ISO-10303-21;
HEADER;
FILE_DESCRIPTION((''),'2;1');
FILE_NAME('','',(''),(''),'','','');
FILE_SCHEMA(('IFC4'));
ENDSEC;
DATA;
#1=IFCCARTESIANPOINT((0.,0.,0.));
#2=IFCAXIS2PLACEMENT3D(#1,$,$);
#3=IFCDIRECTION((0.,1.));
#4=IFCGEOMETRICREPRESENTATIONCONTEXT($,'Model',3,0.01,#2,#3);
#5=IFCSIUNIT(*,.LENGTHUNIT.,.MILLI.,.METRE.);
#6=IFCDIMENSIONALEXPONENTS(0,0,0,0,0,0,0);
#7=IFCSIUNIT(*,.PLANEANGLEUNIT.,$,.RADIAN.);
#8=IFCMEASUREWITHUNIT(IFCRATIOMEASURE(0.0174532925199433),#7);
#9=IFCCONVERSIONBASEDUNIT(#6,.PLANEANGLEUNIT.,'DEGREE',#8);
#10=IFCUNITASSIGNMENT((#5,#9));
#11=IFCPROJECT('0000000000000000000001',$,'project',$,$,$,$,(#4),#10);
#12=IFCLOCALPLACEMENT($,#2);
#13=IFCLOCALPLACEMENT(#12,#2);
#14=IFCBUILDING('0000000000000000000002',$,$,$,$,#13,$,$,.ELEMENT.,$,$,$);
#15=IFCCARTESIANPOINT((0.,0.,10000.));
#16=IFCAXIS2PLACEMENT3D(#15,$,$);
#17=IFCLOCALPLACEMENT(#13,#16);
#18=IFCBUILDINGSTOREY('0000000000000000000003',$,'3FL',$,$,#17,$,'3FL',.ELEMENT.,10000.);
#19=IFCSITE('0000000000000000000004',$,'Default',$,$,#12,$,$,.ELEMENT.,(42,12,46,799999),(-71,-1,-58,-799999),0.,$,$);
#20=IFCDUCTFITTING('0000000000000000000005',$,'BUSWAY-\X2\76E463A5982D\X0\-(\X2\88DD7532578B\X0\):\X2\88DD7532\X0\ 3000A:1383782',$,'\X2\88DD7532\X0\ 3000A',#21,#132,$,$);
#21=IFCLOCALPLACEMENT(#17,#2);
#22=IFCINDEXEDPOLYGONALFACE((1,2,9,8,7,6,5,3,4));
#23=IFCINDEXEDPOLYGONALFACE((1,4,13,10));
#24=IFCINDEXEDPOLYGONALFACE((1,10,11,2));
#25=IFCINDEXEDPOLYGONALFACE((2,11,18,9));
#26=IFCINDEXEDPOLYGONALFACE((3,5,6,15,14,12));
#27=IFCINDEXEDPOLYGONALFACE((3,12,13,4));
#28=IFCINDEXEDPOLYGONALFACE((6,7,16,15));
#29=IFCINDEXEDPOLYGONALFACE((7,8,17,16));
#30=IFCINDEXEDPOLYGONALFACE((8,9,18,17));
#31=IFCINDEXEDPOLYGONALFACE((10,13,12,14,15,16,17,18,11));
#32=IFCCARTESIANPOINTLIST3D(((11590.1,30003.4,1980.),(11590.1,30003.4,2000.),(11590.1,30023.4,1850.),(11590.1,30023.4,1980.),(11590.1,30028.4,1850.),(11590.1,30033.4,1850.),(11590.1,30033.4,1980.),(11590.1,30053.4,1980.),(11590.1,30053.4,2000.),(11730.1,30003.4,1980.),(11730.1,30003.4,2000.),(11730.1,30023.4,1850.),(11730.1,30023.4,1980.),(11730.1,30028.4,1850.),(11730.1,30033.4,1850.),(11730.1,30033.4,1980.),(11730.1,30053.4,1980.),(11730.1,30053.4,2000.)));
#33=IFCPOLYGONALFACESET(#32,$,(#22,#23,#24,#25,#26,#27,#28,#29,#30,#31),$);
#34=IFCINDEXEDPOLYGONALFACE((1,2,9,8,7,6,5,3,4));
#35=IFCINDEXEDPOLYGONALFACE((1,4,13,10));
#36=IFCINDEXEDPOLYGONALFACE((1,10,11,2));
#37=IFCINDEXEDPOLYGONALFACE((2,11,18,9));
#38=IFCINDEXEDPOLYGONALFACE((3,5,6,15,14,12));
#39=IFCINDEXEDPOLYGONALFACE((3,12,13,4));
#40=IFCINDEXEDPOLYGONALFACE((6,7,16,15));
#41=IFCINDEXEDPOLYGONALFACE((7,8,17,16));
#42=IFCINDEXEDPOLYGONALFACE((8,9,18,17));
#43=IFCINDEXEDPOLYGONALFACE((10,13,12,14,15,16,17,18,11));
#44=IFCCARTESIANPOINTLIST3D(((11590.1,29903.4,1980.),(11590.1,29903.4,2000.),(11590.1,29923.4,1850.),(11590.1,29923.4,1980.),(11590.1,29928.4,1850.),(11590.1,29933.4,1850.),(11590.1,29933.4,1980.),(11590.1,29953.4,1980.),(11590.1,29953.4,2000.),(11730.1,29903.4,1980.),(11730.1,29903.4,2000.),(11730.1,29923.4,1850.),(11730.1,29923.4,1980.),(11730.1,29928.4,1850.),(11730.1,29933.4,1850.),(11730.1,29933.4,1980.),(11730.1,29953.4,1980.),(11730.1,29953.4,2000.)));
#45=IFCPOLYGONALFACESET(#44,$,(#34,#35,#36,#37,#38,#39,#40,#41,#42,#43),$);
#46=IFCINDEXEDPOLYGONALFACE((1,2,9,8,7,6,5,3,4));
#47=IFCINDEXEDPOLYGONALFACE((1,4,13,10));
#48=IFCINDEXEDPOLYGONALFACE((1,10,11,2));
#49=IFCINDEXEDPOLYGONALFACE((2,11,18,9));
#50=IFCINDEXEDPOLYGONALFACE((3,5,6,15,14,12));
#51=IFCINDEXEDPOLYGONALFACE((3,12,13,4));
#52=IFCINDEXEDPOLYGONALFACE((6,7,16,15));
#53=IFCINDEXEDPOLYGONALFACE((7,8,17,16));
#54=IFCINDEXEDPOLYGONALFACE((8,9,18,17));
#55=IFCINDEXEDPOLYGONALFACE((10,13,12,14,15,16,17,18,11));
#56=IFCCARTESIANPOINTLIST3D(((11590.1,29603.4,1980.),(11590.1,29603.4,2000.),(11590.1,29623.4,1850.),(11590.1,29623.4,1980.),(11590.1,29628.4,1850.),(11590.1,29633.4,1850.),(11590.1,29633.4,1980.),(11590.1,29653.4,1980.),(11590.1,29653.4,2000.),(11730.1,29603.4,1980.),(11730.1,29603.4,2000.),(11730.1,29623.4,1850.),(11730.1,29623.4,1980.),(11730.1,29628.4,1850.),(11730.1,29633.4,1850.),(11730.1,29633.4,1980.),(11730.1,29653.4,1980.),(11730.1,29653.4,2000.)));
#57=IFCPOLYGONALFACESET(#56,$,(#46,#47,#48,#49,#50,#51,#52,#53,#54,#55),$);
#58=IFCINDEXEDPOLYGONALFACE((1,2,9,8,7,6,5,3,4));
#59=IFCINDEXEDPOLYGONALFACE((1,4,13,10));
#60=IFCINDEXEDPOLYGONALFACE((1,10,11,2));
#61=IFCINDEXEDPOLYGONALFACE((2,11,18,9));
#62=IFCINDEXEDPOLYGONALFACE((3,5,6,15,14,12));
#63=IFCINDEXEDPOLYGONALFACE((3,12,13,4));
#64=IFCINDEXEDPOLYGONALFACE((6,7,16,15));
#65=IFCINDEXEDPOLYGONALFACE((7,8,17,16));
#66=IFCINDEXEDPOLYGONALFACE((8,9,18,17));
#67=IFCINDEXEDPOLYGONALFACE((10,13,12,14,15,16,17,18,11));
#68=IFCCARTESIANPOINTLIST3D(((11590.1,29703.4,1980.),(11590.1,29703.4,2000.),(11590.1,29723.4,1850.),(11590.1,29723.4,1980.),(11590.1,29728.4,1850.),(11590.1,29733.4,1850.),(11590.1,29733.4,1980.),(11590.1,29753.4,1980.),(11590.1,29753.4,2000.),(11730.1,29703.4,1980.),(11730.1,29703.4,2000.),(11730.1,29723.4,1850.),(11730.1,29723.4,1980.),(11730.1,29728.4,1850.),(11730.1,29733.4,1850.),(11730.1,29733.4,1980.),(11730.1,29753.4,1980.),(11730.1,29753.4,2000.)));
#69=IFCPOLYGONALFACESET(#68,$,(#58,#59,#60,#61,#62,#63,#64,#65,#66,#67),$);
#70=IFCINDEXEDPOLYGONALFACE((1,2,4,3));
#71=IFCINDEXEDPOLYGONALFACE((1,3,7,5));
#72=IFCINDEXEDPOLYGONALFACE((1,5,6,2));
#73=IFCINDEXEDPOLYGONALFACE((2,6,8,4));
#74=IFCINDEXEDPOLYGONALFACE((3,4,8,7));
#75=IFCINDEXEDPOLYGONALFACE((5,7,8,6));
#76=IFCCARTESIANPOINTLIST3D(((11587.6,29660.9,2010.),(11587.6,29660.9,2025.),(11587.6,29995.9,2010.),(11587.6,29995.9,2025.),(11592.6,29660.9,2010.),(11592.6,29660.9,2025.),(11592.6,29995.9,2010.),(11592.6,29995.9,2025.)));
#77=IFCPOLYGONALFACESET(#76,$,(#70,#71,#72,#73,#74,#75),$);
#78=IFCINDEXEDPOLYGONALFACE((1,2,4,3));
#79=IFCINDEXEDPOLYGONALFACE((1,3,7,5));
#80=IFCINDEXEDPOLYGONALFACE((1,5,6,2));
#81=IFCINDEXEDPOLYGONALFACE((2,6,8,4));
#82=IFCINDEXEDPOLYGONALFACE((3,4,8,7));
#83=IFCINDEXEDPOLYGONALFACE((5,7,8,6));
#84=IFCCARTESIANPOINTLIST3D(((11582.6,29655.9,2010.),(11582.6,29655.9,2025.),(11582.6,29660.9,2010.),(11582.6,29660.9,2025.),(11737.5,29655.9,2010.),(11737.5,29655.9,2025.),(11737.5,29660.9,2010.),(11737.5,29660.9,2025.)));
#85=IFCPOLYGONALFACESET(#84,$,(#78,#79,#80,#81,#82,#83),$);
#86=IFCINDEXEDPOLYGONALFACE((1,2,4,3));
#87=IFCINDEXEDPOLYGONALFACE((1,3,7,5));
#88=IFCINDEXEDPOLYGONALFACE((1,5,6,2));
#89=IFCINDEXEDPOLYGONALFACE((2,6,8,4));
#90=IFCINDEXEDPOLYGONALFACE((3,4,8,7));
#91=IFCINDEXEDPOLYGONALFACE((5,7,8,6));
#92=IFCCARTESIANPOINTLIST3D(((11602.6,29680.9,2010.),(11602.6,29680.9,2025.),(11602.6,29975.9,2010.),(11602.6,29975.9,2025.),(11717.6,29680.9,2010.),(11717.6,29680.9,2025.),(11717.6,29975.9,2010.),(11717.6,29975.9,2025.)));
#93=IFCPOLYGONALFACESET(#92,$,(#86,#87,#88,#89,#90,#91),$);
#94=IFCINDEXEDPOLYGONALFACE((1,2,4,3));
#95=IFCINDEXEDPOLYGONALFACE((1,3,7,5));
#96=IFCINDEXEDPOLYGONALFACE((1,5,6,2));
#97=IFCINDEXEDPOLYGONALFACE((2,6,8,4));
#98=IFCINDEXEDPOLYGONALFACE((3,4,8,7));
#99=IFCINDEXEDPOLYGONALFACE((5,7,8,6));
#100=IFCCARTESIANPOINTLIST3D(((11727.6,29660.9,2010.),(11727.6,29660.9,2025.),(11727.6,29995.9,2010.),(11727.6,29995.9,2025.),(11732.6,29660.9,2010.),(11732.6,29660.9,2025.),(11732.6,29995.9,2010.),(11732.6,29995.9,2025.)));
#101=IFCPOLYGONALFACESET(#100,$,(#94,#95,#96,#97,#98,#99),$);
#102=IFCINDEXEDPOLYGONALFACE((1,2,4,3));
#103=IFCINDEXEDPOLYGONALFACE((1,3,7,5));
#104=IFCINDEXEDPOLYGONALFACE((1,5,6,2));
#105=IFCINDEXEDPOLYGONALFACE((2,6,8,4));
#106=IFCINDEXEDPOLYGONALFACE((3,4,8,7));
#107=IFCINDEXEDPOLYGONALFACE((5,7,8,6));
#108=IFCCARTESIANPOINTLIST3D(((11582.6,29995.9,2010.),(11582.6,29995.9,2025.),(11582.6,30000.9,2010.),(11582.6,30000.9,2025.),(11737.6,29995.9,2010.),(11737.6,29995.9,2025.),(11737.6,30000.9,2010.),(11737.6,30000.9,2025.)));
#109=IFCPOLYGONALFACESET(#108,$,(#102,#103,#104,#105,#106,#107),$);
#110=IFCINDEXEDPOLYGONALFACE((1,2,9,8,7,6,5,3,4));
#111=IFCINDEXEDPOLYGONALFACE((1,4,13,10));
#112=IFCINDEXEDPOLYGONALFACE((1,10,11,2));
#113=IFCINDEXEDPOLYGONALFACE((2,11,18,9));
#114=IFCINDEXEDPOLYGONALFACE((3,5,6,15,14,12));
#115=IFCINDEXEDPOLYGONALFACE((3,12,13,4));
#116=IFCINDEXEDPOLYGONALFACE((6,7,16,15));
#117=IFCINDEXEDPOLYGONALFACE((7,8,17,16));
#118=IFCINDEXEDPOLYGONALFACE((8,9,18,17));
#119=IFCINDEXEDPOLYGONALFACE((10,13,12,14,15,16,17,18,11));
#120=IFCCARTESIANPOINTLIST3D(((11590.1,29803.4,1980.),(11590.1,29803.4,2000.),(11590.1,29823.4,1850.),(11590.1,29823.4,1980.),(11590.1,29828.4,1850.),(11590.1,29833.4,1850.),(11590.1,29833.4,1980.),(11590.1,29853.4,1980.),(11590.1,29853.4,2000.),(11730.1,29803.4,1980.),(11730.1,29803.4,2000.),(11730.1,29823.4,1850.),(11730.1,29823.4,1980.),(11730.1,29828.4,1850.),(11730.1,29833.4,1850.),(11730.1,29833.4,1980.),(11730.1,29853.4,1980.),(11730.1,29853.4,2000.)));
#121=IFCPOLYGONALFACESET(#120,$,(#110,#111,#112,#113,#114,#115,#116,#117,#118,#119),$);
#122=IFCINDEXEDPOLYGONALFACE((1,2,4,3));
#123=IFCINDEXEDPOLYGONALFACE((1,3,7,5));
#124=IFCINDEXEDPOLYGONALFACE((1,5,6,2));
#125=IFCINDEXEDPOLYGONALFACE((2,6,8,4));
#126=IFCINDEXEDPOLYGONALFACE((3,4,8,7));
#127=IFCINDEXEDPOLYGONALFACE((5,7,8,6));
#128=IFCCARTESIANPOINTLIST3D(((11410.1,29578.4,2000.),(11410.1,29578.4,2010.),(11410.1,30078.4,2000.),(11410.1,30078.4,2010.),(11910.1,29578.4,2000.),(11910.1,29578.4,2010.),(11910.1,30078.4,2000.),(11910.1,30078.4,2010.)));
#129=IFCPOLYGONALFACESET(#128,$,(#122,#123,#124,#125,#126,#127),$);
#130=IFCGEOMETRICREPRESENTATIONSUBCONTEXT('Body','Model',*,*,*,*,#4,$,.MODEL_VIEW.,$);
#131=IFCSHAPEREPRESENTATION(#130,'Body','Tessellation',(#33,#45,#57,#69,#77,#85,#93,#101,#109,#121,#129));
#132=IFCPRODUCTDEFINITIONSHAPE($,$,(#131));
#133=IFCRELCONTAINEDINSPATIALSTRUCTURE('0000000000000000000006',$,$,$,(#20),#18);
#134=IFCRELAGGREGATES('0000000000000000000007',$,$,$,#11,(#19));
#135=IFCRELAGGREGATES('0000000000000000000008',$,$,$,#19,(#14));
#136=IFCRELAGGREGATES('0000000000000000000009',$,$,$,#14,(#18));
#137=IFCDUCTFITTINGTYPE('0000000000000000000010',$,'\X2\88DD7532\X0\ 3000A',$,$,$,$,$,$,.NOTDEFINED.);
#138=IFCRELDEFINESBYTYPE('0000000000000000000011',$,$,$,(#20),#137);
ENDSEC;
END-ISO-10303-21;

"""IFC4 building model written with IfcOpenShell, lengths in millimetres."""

from ifc_helpers import new_model, entity, si_unit, converted_unit, direction, frame, frame_2d, origin, origin_2d_with_axis, place, context, subcontext, project, spatial, polyline, rectangle, outline, extrude, source, transform, mapped, type_object, type_shapes, element, save


model = new_model("IFC4")

# Units and contexts
model_context = context("Model", 3, precision=0.01, world=origin(), true_north=direction((0.0, 1.0)))
body_context = subcontext(model_context, "Body", "Model", "MODEL_VIEW")
ifc_project = project(units=[si_unit("LENGTHUNIT", "METRE", prefix="MILLI"), converted_unit("PLANEANGLEUNIT", "DEGREE", entity("IfcRatioMeasure", 0.0174532925199433), si_unit("PLANEANGLEUNIT", "RADIAN"), dimensions=[0, 0, 0, 0, 0, 0, 0])], contexts=[model_context])

# Site, building, storey
site_placement = place(None, origin())
site = spatial("IfcSite", under=ifc_project, at=site_placement, Name="Default", CompositionType="ELEMENT", RefLatitude=(42, 12, 46, 799999), RefLongitude=(-71, -1, -58, -799999), RefElevation=0.0)
building_placement = place(site_placement, origin())
building = spatial("IfcBuilding", under=site, at=building_placement, CompositionType="ELEMENT")
storey_placement = place(building_placement, frame((0.0, 0.0, 10000.0)))
storey = spatial("IfcBuildingStorey", under=building, at=storey_placement, Name="3FL", LongName="3FL", CompositionType="ELEMENT", Elevation=10000.0)

# Duct fitting
duct_fitting_type_1 = type_object("IfcDuctFittingType", Name="裝甲 3000A", PredefinedType="NOTDEFINED")
shared_shape_1 = source(origin(), body_context, "Body", "SweptSolid", [
    extrude(outline(polyline([(-25.0, -58.9), (25.0, -58.9), (25.0, -38.9), (5.0, -38.9), (5.0, 91.1), (0.0, 91.1), (-5.0, 91.1), (-5.0, -38.9), (-25.0, -38.9), (-25.0, -58.9)])), frame((-200.0, -70.0, -58.9), z_axis=(0.0, 1.0, 0.0), x_axis=(1.0, 0.0, 0.0)), (0.0, 0.0, 1.0), 140.0),
    extrude(outline(polyline([(-25.0, -58.9), (25.0, -58.9), (25.0, -38.9), (5.0, -38.9), (5.0, 91.1), (0.0, 91.1), (-5.0, 91.1), (-5.0, -38.9), (-25.0, -38.9), (-25.0, -58.9)])), frame((-100.0, -70.0, -58.9), z_axis=(0.0, 1.0, 0.0), x_axis=(1.0, 0.0, 0.0)), (0.0, 0.0, 1.0), 140.0),
    extrude(outline(polyline([(-58.9, -25.0), (-38.9, -25.0), (-38.9, -5.0), (91.1, -5.0), (91.1, 0.0), (91.1, 5.0), (-38.9, 5.0), (-38.9, 25.0), (-58.9, 25.0), (-58.9, -25.0)])), frame((200.0, -70.0, -58.9), z_axis=(0.0, 1.0, 0.0), x_axis=(0.0, 0.0, -1.0)), (0.0, 0.0, 1.0), 140.0),
    extrude(outline(polyline([(-58.9, -25.0), (-38.9, -25.0), (-38.9, -5.0), (91.1, -5.0), (91.1, 0.0), (91.1, 5.0), (-38.9, 5.0), (-38.9, 25.0), (-58.9, 25.0), (-58.9, -25.0)])), frame((100.0, -70.0, -58.9), z_axis=(0.0, 1.0, 0.0), x_axis=(0.0, 0.0, -1.0)), (0.0, 0.0, 1.0), 140.0),
    extrude(rectangle(XDim=335.0, YDim=5.0, at=origin_2d_with_axis()), frame((0.0, -70.0, 10.0), z_axis=(0.0, 0.0, 1.0), x_axis=(-1.0, 0.0, 0.0)), (0.0, 0.0, 1.0), 15.0),
    extrude(rectangle(XDim=5.0, YDim=154.9, at=frame_2d((0.0, 0.0), x_axis=(1.0, 0.0))), frame((170.0, -0.1, 10.0), z_axis=(0.0, 0.0, 1.0), x_axis=(-1.0, 0.0, 0.0)), (0.0, 0.0, 1.0), 15.0),
    extrude(rectangle(XDim=295.0, YDim=115.0, at=origin_2d_with_axis()), frame((0.0, 0.0, 10.0), z_axis=(0.0, 0.0, 1.0), x_axis=(-1.0, 0.0, 0.0)), (0.0, 0.0, 1.0), 15.0),
    extrude(rectangle(XDim=335.0, YDim=5.0, at=origin_2d_with_axis()), frame((0.0, 70.0, 10.0), z_axis=(0.0, 0.0, 1.0), x_axis=(-1.0, 0.0, 0.0)), (0.0, 0.0, 1.0), 15.0),
    extrude(rectangle(XDim=5.0, YDim=155.0, at=origin_2d_with_axis()), frame((-170.0, 0.0, 10.0), z_axis=(0.0, 0.0, 1.0), x_axis=(-1.0, 0.0, 0.0)), (0.0, 0.0, 1.0), 15.0),
    extrude(outline(polyline([(-58.9, -25.0), (-38.9, -25.0), (-38.9, -5.0), (91.1, -5.0), (91.1, 0.0), (91.1, 5.0), (-38.9, 5.0), (-38.9, 25.0), (-58.9, 25.0), (-58.9, -25.0)])), frame((0.0, -70.0, -58.9), z_axis=(0.0, 1.0, 0.0), x_axis=(0.0, 0.0, -1.0)), (0.0, 0.0, 1.0), 140.0),
    extrude(rectangle(XDim=500.0, YDim=500.0, at=origin_2d_with_axis()), frame((0.0, 0.0, 0.0), z_axis=(0.0, 0.0, 1.0), x_axis=(0.0, 1.0, 0.0)), (0.0, 0.0, 1.0), 10.0),
])
type_shapes(duct_fitting_type_1, [shared_shape_1])
duct_fitting_1_placement = place(storey_placement, frame((11660.1, 29828.4, 2000.0), z_axis=(0.0, 0.0, 1.0), x_axis=(0.0, -1.0, 0.0)))
element("IfcDuctFitting", 1, at=duct_fitting_1_placement, inside=storey, type_object=duct_fitting_type_1, Name="BUSWAY-盤接頭-(裝甲型):裝甲 3000A:1383782", ObjectType="裝甲 3000A", context=body_context, shape_type="MappedRepresentation", body=[
    mapped(shared_shape_1, transform((0.0, 0.0, 0.0), scale=1.0)),
])

save(model, "model.ifc")
